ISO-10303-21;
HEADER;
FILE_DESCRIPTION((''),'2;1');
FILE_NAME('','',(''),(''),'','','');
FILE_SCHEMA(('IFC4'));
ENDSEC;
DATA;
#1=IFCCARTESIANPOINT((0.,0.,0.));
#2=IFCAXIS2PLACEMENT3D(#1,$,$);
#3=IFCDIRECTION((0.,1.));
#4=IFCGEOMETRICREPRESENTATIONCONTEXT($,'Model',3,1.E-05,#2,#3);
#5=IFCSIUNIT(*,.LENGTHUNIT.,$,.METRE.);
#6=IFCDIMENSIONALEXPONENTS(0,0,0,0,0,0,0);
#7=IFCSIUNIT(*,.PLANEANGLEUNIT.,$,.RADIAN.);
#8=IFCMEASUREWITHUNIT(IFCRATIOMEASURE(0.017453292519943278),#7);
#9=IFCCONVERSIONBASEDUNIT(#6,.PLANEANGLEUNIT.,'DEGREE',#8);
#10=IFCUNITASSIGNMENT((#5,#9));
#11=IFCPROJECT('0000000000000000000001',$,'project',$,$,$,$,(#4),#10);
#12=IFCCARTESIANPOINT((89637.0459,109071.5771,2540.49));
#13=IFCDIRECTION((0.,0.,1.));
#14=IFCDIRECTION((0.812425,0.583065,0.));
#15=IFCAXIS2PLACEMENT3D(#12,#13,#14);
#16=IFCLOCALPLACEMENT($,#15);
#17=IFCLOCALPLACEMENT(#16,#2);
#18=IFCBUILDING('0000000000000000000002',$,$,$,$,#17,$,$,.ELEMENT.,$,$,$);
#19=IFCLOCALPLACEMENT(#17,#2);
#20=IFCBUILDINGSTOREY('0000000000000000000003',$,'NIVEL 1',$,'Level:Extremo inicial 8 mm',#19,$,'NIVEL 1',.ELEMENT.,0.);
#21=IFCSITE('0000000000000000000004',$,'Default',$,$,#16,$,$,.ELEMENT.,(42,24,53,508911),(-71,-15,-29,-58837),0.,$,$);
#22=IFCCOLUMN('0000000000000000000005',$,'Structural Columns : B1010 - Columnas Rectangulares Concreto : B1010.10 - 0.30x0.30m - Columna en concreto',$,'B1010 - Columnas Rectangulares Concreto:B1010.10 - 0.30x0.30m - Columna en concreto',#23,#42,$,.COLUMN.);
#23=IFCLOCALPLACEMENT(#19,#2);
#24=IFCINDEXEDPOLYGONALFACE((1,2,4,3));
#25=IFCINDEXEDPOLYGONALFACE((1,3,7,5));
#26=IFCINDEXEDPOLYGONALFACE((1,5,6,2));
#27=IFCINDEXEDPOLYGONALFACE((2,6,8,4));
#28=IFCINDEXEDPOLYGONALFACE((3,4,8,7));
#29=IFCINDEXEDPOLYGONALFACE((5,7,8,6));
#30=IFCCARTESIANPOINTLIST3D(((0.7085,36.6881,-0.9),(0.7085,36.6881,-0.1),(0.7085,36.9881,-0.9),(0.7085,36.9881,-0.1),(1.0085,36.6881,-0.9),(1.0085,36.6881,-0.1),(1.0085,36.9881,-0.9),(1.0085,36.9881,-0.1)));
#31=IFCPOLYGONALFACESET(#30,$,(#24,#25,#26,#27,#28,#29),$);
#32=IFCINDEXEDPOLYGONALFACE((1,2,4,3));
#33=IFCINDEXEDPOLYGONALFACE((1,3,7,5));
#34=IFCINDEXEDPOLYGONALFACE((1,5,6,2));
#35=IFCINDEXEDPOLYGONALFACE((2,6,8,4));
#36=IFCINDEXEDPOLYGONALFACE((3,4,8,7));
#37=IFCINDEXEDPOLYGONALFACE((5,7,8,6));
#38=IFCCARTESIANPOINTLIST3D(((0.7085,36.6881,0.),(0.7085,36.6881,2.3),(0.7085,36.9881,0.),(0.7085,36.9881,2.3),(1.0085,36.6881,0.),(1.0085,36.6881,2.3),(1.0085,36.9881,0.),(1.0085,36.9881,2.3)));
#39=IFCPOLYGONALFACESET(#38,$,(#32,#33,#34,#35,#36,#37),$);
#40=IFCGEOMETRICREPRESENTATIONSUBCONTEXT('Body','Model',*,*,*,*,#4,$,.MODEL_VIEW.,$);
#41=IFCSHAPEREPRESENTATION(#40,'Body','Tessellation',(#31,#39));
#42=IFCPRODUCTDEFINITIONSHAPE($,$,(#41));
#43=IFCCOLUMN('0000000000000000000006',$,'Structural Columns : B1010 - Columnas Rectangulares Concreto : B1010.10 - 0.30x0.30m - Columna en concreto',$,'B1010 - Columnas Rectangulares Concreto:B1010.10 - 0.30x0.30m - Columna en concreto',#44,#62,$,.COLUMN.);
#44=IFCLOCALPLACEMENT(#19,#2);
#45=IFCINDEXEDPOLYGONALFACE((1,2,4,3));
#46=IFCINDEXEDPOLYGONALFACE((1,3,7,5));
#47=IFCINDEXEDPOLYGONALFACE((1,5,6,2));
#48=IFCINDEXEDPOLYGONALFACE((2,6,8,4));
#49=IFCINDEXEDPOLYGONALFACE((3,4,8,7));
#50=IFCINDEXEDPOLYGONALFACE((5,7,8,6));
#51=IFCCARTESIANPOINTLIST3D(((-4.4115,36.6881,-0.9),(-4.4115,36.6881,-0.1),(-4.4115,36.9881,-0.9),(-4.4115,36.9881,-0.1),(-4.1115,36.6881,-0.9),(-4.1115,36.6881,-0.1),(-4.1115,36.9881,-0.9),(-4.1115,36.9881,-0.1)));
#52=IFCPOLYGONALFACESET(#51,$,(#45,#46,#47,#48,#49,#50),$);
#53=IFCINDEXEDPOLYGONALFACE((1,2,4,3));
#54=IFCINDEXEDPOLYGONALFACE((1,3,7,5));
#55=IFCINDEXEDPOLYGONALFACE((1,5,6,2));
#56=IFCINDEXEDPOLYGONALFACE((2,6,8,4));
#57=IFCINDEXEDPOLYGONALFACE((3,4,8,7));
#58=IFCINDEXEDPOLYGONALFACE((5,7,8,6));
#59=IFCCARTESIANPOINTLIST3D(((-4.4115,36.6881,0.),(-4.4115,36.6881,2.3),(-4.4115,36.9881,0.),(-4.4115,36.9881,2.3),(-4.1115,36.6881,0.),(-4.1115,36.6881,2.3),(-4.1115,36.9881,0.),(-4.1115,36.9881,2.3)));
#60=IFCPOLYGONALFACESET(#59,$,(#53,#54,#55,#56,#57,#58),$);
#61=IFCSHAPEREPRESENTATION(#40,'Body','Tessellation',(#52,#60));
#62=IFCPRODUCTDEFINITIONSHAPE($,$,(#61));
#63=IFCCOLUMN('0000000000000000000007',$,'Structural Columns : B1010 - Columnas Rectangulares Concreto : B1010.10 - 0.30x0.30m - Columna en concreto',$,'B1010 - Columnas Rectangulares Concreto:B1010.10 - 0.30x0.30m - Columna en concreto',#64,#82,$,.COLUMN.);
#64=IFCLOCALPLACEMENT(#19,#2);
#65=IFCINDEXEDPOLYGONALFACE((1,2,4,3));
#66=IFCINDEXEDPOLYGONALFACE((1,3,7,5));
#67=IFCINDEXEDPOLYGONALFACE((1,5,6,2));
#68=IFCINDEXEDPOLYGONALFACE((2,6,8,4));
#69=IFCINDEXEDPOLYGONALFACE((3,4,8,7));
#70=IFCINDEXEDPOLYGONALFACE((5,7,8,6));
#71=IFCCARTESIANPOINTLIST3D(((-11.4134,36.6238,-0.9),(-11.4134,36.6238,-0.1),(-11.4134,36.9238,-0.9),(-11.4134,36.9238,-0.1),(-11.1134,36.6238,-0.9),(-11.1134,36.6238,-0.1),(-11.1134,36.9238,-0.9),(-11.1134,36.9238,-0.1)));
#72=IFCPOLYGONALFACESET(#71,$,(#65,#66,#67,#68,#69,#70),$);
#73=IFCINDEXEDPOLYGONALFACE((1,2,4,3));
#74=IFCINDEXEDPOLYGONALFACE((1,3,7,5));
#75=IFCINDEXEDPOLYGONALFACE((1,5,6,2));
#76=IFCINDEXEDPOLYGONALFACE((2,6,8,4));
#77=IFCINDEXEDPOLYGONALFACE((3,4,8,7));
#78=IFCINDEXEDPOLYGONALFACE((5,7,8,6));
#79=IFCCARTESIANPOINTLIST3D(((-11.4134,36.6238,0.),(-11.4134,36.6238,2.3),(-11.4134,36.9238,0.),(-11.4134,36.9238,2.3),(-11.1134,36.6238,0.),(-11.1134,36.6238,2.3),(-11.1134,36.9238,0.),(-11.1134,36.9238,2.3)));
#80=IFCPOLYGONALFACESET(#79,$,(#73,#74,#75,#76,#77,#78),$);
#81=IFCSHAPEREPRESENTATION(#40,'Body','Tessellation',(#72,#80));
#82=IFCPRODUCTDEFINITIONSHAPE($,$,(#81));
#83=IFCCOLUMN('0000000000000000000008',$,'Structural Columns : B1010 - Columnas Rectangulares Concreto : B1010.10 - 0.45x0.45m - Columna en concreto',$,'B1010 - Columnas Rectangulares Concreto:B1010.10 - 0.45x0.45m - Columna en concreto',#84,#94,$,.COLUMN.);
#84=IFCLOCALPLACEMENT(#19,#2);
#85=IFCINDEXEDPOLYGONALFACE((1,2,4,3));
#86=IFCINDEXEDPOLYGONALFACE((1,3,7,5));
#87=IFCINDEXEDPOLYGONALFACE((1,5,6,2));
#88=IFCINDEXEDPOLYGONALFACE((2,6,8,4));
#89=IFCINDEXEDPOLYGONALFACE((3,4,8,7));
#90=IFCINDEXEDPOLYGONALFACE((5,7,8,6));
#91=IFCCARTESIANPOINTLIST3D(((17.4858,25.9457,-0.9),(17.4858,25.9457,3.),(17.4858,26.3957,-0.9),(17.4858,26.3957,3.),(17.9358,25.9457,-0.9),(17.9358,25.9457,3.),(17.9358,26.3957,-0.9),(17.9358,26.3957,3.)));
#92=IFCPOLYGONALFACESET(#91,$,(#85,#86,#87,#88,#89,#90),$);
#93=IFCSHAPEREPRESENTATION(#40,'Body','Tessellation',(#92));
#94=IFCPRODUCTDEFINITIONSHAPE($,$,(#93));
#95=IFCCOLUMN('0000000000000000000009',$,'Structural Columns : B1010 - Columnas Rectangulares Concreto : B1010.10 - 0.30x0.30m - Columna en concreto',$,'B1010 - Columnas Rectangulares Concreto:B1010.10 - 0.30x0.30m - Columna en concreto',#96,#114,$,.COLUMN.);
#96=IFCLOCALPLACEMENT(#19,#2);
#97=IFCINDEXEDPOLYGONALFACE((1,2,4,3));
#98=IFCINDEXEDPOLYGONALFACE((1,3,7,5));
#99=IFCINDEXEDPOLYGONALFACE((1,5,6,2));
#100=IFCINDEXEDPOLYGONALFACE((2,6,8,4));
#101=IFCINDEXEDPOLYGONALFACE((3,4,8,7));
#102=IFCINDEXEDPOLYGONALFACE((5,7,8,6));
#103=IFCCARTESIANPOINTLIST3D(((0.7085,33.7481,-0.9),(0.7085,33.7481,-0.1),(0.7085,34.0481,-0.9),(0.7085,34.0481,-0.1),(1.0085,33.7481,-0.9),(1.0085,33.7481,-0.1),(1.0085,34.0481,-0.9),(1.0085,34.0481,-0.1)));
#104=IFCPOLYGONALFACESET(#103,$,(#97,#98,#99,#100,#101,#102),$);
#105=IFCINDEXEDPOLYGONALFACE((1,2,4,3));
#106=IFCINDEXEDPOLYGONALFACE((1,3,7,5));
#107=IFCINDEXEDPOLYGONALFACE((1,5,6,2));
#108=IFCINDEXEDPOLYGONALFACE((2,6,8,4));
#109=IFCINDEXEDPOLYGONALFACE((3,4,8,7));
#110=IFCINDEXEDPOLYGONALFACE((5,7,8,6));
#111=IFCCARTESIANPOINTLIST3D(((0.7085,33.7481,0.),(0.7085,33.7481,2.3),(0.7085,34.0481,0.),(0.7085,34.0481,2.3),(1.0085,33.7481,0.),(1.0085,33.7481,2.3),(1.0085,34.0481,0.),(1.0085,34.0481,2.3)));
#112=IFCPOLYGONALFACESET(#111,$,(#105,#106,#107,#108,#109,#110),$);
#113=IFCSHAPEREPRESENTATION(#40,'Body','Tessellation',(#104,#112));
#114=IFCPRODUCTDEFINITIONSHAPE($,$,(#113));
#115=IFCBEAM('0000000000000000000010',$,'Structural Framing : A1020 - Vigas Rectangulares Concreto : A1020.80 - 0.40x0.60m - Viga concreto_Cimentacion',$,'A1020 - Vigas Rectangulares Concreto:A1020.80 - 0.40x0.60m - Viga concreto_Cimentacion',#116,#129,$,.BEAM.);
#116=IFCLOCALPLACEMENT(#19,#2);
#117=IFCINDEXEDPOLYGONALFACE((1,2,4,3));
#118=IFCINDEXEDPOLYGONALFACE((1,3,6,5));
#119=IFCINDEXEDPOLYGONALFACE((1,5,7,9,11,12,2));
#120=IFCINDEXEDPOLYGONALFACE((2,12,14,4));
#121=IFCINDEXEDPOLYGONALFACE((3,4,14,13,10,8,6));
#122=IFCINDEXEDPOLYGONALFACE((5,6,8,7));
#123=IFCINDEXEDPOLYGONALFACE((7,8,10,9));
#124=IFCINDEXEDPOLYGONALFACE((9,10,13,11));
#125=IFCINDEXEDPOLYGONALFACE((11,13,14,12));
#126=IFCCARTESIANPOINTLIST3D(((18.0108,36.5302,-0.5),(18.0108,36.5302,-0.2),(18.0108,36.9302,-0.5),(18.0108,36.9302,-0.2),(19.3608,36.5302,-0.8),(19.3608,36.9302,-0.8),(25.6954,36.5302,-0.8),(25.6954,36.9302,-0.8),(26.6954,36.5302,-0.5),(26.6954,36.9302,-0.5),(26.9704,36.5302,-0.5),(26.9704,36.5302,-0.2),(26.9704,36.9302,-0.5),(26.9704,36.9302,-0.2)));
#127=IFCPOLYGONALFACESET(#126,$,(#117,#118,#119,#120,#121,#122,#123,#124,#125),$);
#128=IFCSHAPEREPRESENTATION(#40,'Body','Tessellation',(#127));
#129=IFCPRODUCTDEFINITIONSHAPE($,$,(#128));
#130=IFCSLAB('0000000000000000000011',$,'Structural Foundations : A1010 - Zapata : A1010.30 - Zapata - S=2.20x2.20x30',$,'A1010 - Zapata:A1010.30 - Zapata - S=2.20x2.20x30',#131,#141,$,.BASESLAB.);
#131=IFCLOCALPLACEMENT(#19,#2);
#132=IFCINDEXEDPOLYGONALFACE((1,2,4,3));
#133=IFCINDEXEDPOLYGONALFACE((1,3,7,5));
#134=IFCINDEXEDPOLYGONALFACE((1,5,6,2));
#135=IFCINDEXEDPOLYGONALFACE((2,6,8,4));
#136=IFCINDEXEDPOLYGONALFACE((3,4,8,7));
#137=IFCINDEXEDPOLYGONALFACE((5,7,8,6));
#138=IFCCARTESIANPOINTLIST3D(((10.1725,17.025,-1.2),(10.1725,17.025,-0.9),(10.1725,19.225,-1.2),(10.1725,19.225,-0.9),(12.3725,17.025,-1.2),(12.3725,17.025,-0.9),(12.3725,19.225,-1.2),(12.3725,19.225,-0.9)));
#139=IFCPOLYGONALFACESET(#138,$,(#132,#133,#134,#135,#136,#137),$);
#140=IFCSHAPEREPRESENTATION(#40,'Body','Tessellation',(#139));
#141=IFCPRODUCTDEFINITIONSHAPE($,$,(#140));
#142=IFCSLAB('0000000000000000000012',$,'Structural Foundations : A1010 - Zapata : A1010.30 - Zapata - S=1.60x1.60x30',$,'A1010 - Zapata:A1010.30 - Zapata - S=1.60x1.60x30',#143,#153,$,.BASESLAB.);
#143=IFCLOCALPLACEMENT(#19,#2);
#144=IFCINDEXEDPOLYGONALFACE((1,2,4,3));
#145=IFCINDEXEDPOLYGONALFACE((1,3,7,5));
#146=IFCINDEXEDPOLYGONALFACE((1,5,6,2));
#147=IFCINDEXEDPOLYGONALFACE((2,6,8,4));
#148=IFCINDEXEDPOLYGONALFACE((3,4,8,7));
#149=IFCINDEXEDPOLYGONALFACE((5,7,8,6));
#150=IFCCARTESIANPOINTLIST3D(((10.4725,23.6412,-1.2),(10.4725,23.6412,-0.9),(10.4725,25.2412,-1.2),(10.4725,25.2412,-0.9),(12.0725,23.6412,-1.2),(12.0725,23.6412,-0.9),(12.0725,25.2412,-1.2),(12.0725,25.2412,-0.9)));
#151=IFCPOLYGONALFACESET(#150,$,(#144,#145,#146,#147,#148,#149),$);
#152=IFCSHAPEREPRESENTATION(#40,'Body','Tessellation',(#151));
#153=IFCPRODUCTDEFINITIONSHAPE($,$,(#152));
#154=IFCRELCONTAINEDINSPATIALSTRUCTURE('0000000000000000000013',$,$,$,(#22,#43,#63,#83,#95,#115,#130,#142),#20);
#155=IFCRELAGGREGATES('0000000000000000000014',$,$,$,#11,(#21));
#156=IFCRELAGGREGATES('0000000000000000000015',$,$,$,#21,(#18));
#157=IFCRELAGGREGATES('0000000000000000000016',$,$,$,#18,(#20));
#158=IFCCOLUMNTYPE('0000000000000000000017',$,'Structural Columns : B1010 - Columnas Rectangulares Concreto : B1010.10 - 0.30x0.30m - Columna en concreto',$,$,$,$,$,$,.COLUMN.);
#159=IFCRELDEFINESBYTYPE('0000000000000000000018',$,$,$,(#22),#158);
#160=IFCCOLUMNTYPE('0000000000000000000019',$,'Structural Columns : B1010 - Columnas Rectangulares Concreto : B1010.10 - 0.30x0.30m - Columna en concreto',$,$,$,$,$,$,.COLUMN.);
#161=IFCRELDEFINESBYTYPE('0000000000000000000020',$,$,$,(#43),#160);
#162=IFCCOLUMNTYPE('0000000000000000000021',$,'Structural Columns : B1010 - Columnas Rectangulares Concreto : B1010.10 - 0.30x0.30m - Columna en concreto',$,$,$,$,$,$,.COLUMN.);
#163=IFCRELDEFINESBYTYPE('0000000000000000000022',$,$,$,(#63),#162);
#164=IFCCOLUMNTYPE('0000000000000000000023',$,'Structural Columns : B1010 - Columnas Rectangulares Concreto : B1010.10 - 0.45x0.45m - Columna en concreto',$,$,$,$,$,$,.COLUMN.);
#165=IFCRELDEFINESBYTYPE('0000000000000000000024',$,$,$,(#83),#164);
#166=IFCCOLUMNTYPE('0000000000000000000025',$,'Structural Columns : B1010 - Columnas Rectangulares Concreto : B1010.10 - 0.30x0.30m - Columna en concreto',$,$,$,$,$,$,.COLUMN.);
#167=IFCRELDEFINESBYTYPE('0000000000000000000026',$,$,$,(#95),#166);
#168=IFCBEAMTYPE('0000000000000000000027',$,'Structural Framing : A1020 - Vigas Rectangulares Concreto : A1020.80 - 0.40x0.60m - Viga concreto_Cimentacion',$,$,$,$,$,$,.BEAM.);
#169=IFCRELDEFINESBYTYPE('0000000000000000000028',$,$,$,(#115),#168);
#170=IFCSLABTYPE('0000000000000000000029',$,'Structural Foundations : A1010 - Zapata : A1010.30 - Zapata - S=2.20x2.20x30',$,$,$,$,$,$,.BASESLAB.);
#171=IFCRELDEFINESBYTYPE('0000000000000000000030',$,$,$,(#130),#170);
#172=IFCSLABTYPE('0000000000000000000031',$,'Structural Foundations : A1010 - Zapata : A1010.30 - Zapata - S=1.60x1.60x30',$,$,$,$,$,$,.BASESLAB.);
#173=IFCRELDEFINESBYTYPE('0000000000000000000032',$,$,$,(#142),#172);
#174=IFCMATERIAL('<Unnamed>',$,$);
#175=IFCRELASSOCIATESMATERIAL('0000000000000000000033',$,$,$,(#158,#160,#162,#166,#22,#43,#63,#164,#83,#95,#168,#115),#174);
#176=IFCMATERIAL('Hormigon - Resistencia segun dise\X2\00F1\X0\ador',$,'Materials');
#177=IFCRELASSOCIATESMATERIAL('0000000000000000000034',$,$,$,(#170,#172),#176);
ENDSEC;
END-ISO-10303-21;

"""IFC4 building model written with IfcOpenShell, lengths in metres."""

from ifc_helpers import new_model, entity, si_unit, converted_unit, direction, frame, frame_2d, origin, origin_2d_with_axis, place, context, subcontext, project, spatial, polyline, segment, composite_curve, rectangle, outline, extrude, source, transform, mapped, material, material_profile, profile_set, profile_usage, type_object, type_shapes, element, save


model = new_model("IFC4")

# Units and contexts
model_context = context("Model", 3, precision=1e-05, world=origin(), true_north=direction((0.0, 1.0)))
body_context = subcontext(model_context, "Body", "Model", "MODEL_VIEW")
ifc_project = project(units=[si_unit("LENGTHUNIT", "METRE"), converted_unit("PLANEANGLEUNIT", "DEGREE", entity("IfcRatioMeasure", 0.017453292519943278), si_unit("PLANEANGLEUNIT", "RADIAN"), dimensions=[0, 0, 0, 0, 0, 0, 0])], contexts=[model_context])

# Site, building, storey
site_placement = place(None, frame((89637.0459, 109071.5771, 2540.49), z_axis=(0.0, 0.0, 1.0), x_axis=(0.812425, 0.583065, 0.0)))
site = spatial("IfcSite", under=ifc_project, at=site_placement, Name="Default", CompositionType="ELEMENT", RefLatitude=(42, 24, 53, 508911), RefLongitude=(-71, -15, -29, -58837), RefElevation=0.0)
building_placement = place(site_placement, origin())
building = spatial("IfcBuilding", under=site, at=building_placement, CompositionType="ELEMENT")
storey_placement = place(building_placement, origin())
storey = spatial("IfcBuildingStorey", under=building, at=storey_placement, Name="NIVEL 1", ObjectType="Level:Extremo inicial 8 mm", LongName="NIVEL 1", CompositionType="ELEMENT", Elevation=0.0)

# Columns
ifc_material_1 = material(Name="<Unnamed>")
ifc_material_profile_1 = material_profile(ifc_material_1, outline(composite_curve([segment(polyline([(0.15, 0.15, 0.0), (0.15, -0.15, 0.0)]), True, "CONTINUOUS"), segment(polyline([(0.15, -0.15, 0.0), (-0.15, -0.15, 0.0)]), True, "CONTINUOUS"), segment(polyline([(-0.15, -0.15, 0.0), (-0.15, 0.15, 0.0)]), True, "CONTINUOUS"), segment(polyline([(-0.15, 0.15, 0.0), (0.15, 0.15, 0.0)]), True, "CONTINUOUS")], self_intersect=False), kind="CURVE"), Name="B1010.10 - 0.30x0.30m - Columna en concreto")
ifc_material_profile_2 = material_profile(ifc_material_1, outline(composite_curve([segment(polyline([(0.15, 0.15, 2.3), (-0.15, 0.15, 2.3)]), True, "CONTINUOUS"), segment(polyline([(-0.15, 0.15, 2.3), (-0.15, -0.15, 2.3)]), True, "CONTINUOUS"), segment(polyline([(-0.15, -0.15, 2.3), (0.15, -0.15, 2.3)]), True, "CONTINUOUS"), segment(polyline([(0.15, -0.15, 2.3), (0.15, 0.15, 2.3)]), True, "CONTINUOUS")], self_intersect=False), kind="CURVE"), Name="B1010.10 - 0.30x0.30m - Columna en concreto")
ifc_profile_set_1 = profile_set([ifc_material_profile_1, ifc_material_profile_2], Name="B1010.10 - 0.30x0.30m - Columna en concreto")
ifc_profile_usage_1 = profile_usage(ifc_profile_set_1)
column_type_1 = type_object("IfcColumnType", Name="Structural Columns : B1010 - Columnas Rectangulares Concreto : B1010.10 - 0.30x0.30m - Columna en concreto", PredefinedType="COLUMN", material=ifc_profile_set_1)
shared_shape_1 = source(origin(), body_context, "Body", "SweptSolid", [
    extrude(rectangle(XDim=0.3, YDim=0.3, at=origin_2d_with_axis()), frame((0.8585, 36.8381, -0.9), z_axis=(0.0, 0.0, 1.0), x_axis=(0.0, -1.0, 0.0)), (0.0, 0.0, 1.0), 0.8),
    extrude(rectangle(XDim=0.3, YDim=0.3, at=origin_2d_with_axis()), frame((0.8585, 36.8381, 0.0), z_axis=(0.0, 0.0, 1.0), x_axis=(0.0, -1.0, 0.0)), (0.0, 0.0, 1.0), 2.3),
])
type_shapes(column_type_1, [shared_shape_1])
column_1_placement = place(storey_placement, origin())
element("IfcColumn", 1, at=column_1_placement, inside=storey, type_object=column_type_1, material=ifc_profile_usage_1, Name="Structural Columns : B1010 - Columnas Rectangulares Concreto : B1010.10 - 0.30x0.30m - Columna en concreto", ObjectType="B1010 - Columnas Rectangulares Concreto:B1010.10 - 0.30x0.30m - Columna en concreto", PredefinedType="COLUMN", context=body_context, shape_type="MappedRepresentation", body=[
    mapped(shared_shape_1, transform((0.0, 0.0, 0.0), scale=1.0)),
])
ifc_profile_usage_2 = profile_usage(ifc_profile_set_1)
column_type_2 = type_object("IfcColumnType", Name="Structural Columns : B1010 - Columnas Rectangulares Concreto : B1010.10 - 0.30x0.30m - Columna en concreto", PredefinedType="COLUMN", material=ifc_profile_set_1)
shared_shape_2 = source(origin(), body_context, "Body", "SweptSolid", [
    extrude(rectangle(XDim=0.3, YDim=0.3, at=origin_2d_with_axis()), frame((-4.2615, 36.8381, -0.9), z_axis=(0.0, 0.0, 1.0), x_axis=(0.0, -1.0, 0.0)), (0.0, 0.0, 1.0), 0.8),
    extrude(rectangle(XDim=0.3, YDim=0.3, at=origin_2d_with_axis()), frame((-4.2615, 36.8381, 0.0), z_axis=(0.0, 0.0, 1.0), x_axis=(0.0, -1.0, 0.0)), (0.0, 0.0, 1.0), 2.3),
])
type_shapes(column_type_2, [shared_shape_2])
column_2_placement = place(storey_placement, origin())
element("IfcColumn", 2, at=column_2_placement, inside=storey, type_object=column_type_2, material=ifc_profile_usage_2, Name="Structural Columns : B1010 - Columnas Rectangulares Concreto : B1010.10 - 0.30x0.30m - Columna en concreto", ObjectType="B1010 - Columnas Rectangulares Concreto:B1010.10 - 0.30x0.30m - Columna en concreto", PredefinedType="COLUMN", context=body_context, shape_type="MappedRepresentation", body=[
    mapped(shared_shape_2, transform((0.0, 0.0, 0.0), scale=1.0)),
])
ifc_profile_usage_3 = profile_usage(ifc_profile_set_1)
column_type_3 = type_object("IfcColumnType", Name="Structural Columns : B1010 - Columnas Rectangulares Concreto : B1010.10 - 0.30x0.30m - Columna en concreto", PredefinedType="COLUMN", material=ifc_profile_set_1)
shared_shape_3 = source(origin(), body_context, "Body", "SweptSolid", [
    extrude(rectangle(XDim=0.3, YDim=0.3, at=origin_2d_with_axis()), frame((-11.2634, 36.7738, -0.9), z_axis=(0.0, 0.0, 1.0), x_axis=(0.0, -1.0, 0.0)), (0.0, 0.0, 1.0), 0.8),
    extrude(rectangle(XDim=0.3, YDim=0.3, at=origin_2d_with_axis()), frame((-11.2634, 36.7738, 0.0), z_axis=(0.0, 0.0, 1.0), x_axis=(0.0, -1.0, 0.0)), (0.0, 0.0, 1.0), 2.3),
])
type_shapes(column_type_3, [shared_shape_3])
column_3_placement = place(storey_placement, origin())
element("IfcColumn", 3, at=column_3_placement, inside=storey, type_object=column_type_3, material=ifc_profile_usage_3, Name="Structural Columns : B1010 - Columnas Rectangulares Concreto : B1010.10 - 0.30x0.30m - Columna en concreto", ObjectType="B1010 - Columnas Rectangulares Concreto:B1010.10 - 0.30x0.30m - Columna en concreto", PredefinedType="COLUMN", context=body_context, shape_type="MappedRepresentation", body=[
    mapped(shared_shape_3, transform((0.0, 0.0, 0.0), scale=1.0)),
])
ifc_material_profile_3 = material_profile(ifc_material_1, outline(composite_curve([segment(polyline([(0.225, 0.225, 0.0), (0.225, -0.225, 0.0)]), True, "CONTINUOUS"), segment(polyline([(0.225, -0.225, 0.0), (-0.225, -0.225, 0.0)]), True, "CONTINUOUS"), segment(polyline([(-0.225, -0.225, 0.0), (-0.225, 0.225, 0.0)]), True, "CONTINUOUS"), segment(polyline([(-0.225, 0.225, 0.0), (0.225, 0.225, 0.0)]), True, "CONTINUOUS")], self_intersect=False), kind="CURVE"), Name="B1010.10 - 0.45x0.45m - Columna en concreto")
ifc_material_profile_4 = material_profile(ifc_material_1, outline(composite_curve([segment(polyline([(0.225, 0.225, 3.0), (-0.225, 0.225, 3.0)]), True, "CONTINUOUS"), segment(polyline([(-0.225, 0.225, 3.0), (-0.225, -0.225, 3.0)]), True, "CONTINUOUS"), segment(polyline([(-0.225, -0.225, 3.0), (0.225, -0.225, 3.0)]), True, "CONTINUOUS"), segment(polyline([(0.225, -0.225, 3.0), (0.225, 0.225, 3.0)]), True, "CONTINUOUS")], self_intersect=False), kind="CURVE"), Name="B1010.10 - 0.45x0.45m - Columna en concreto")
ifc_profile_set_2 = profile_set([ifc_material_profile_3, ifc_material_profile_4], Name="B1010.10 - 0.45x0.45m - Columna en concreto")
ifc_profile_usage_4 = profile_usage(ifc_profile_set_2)
column_type_4 = type_object("IfcColumnType", Name="Structural Columns : B1010 - Columnas Rectangulares Concreto : B1010.10 - 0.45x0.45m - Columna en concreto", PredefinedType="COLUMN", material=ifc_profile_set_2)
shared_shape_4 = source(origin(), body_context, "Body", "SweptSolid", [
    extrude(rectangle(XDim=0.45, YDim=0.45, at=origin_2d_with_axis()), frame((17.7108, 26.1707, -0.9), z_axis=(0.0, 0.0, 1.0), x_axis=(0.0, -1.0, 0.0)), (0.0, 0.0, 1.0), 3.9),
])
type_shapes(column_type_4, [shared_shape_4])
column_4_placement = place(storey_placement, origin())
element("IfcColumn", 4, at=column_4_placement, inside=storey, type_object=column_type_4, material=ifc_profile_usage_4, Name="Structural Columns : B1010 - Columnas Rectangulares Concreto : B1010.10 - 0.45x0.45m - Columna en concreto", ObjectType="B1010 - Columnas Rectangulares Concreto:B1010.10 - 0.45x0.45m - Columna en concreto", PredefinedType="COLUMN", context=body_context, shape_type="MappedRepresentation", body=[
    mapped(shared_shape_4, transform((0.0, 0.0, 0.0), scale=1.0)),
])
ifc_profile_usage_5 = profile_usage(ifc_profile_set_1)
column_type_5 = type_object("IfcColumnType", Name="Structural Columns : B1010 - Columnas Rectangulares Concreto : B1010.10 - 0.30x0.30m - Columna en concreto", PredefinedType="COLUMN", material=ifc_profile_set_1)
shared_shape_5 = source(origin(), body_context, "Body", "SweptSolid", [
    extrude(rectangle(XDim=0.3, YDim=0.3, at=origin_2d_with_axis()), frame((0.8585, 33.8981, -0.9), z_axis=(0.0, 0.0, 1.0), x_axis=(0.0, -1.0, 0.0)), (0.0, 0.0, 1.0), 0.8),
    extrude(rectangle(XDim=0.3, YDim=0.3, at=origin_2d_with_axis()), frame((0.8585, 33.8981, 0.0), z_axis=(0.0, 0.0, 1.0), x_axis=(0.0, -1.0, 0.0)), (0.0, 0.0, 1.0), 2.3),
])
type_shapes(column_type_5, [shared_shape_5])
column_5_placement = place(storey_placement, origin())
element("IfcColumn", 5, at=column_5_placement, inside=storey, type_object=column_type_5, material=ifc_profile_usage_5, Name="Structural Columns : B1010 - Columnas Rectangulares Concreto : B1010.10 - 0.30x0.30m - Columna en concreto", ObjectType="B1010 - Columnas Rectangulares Concreto:B1010.10 - 0.30x0.30m - Columna en concreto", PredefinedType="COLUMN", context=body_context, shape_type="MappedRepresentation", body=[
    mapped(shared_shape_5, transform((0.0, 0.0, 0.0), scale=1.0)),
])

# Beam
ifc_material_profile_5 = material_profile(ifc_material_1, outline(composite_curve([segment(polyline([(-0.2, 0.3, 0.0), (0.2, 0.3, 0.0)]), True, "CONTINUOUS"), segment(polyline([(0.2, 0.3, 0.0), (0.2, -0.3, 0.0)]), True, "CONTINUOUS"), segment(polyline([(0.2, -0.3, 0.0), (-0.2, -0.3, 0.0)]), True, "CONTINUOUS"), segment(polyline([(-0.2, -0.3, 0.0), (-0.2, 0.3, 0.0)]), True, "CONTINUOUS")], self_intersect=False), kind="CURVE"), Name="A1020.80 - 0.40x0.60m - Viga concreto_Cimentacion")
ifc_material_profile_6 = material_profile(ifc_material_1, outline(composite_curve([segment(polyline([(6.4409, -0.2, 0.3), (6.4409, -0.2, -0.3)]), True, "CONTINUOUS"), segment(polyline([(6.4409, -0.2, -0.3), (6.4409, 0.2, -0.3)]), True, "CONTINUOUS"), segment(polyline([(6.4409, 0.2, -0.3), (6.4409, 0.2, 0.3)]), True, "CONTINUOUS"), segment(polyline([(6.4409, 0.2, 0.3), (6.4409, -0.2, 0.3)]), True, "CONTINUOUS")], self_intersect=False), kind="CURVE"), Name="A1020.80 - 0.40x0.60m - Viga concreto_Cimentacion")
ifc_profile_set_3 = profile_set([ifc_material_profile_5, ifc_material_profile_6], Name="A1020.80 - 0.40x0.60m - Viga concreto_Cimentacion")
ifc_profile_usage_6 = profile_usage(ifc_profile_set_3, cardinal=8)
beam_type_1 = type_object("IfcBeamType", Name="Structural Framing : A1020 - Vigas Rectangulares Concreto : A1020.80 - 0.40x0.60m - Viga concreto_Cimentacion", PredefinedType="BEAM", material=ifc_profile_set_3)
shared_shape_6 = source(origin(), body_context, "Body", "SweptSolid", [
    extrude(outline(polyline([(0.0, -5.0912), (0.3, -5.0912), (0.3, 3.8684), (0.0, 3.8684), (0.0, 3.5934), (-0.3, 2.5934), (-0.3, -3.7412), (0.0, -5.0912)])), frame((5.0912, 0.0, 0.3), z_axis=(0.0, 1.0, 0.0), x_axis=(0.0, 0.0, 1.0)), (0.0, 0.0, 1.0), 0.4),
])
type_shapes(beam_type_1, [shared_shape_6])
beam_1_placement = place(storey_placement, frame((18.0108, 36.5302, -0.8)))
element("IfcBeam", 6, at=beam_1_placement, inside=storey, type_object=beam_type_1, material=ifc_profile_usage_6, Name="Structural Framing : A1020 - Vigas Rectangulares Concreto : A1020.80 - 0.40x0.60m - Viga concreto_Cimentacion", ObjectType="A1020 - Vigas Rectangulares Concreto:A1020.80 - 0.40x0.60m - Viga concreto_Cimentacion", PredefinedType="BEAM", context=body_context, shape_type="MappedRepresentation", body=[
    mapped(shared_shape_6, transform((0.0, 0.0, 0.0), scale=1.0)),
])

# Slabs
ifc_material_2 = material(Name="Hormigon - Resistencia segun diseñador", Category="Materials")
slab_type_1 = type_object("IfcSlabType", Name="Structural Foundations : A1010 - Zapata : A1010.30 - Zapata - S=2.20x2.20x30", PredefinedType="BASESLAB", material=ifc_material_2)
slab_1_placement = place(storey_placement, frame((10.1725, 17.025, -1.2)))
element("IfcSlab", 7, at=slab_1_placement, inside=storey, type_object=slab_type_1, Name="Structural Foundations : A1010 - Zapata : A1010.30 - Zapata - S=2.20x2.20x30", ObjectType="A1010 - Zapata:A1010.30 - Zapata - S=2.20x2.20x30", PredefinedType="BASESLAB", context=body_context, shape_type="SweptSolid", body=[
    extrude(rectangle(XDim=2.2, YDim=2.2, at=frame_2d((0.0, 0.0), x_axis=(1.0, 0.0))), frame((1.1, 1.1, 0.0), z_axis=(0.0, 0.0, 1.0), x_axis=(-1.0, 0.0, 0.0)), (0.0, 0.0, 1.0), 0.3),
])
slab_type_2 = type_object("IfcSlabType", Name="Structural Foundations : A1010 - Zapata : A1010.30 - Zapata - S=1.60x1.60x30", PredefinedType="BASESLAB", material=ifc_material_2)
slab_2_placement = place(storey_placement, frame((10.4725, 23.6412, -1.2)))
element("IfcSlab", 8, at=slab_2_placement, inside=storey, type_object=slab_type_2, Name="Structural Foundations : A1010 - Zapata : A1010.30 - Zapata - S=1.60x1.60x30", ObjectType="A1010 - Zapata:A1010.30 - Zapata - S=1.60x1.60x30", PredefinedType="BASESLAB", context=body_context, shape_type="SweptSolid", body=[
    extrude(rectangle(XDim=1.6, YDim=1.6, at=origin_2d_with_axis()), frame((0.8, 0.8, 0.0), z_axis=(0.0, 0.0, 1.0), x_axis=(-1.0, 0.0, 0.0)), (0.0, 0.0, 1.0), 0.3),
])

save(model, "model.ifc")
